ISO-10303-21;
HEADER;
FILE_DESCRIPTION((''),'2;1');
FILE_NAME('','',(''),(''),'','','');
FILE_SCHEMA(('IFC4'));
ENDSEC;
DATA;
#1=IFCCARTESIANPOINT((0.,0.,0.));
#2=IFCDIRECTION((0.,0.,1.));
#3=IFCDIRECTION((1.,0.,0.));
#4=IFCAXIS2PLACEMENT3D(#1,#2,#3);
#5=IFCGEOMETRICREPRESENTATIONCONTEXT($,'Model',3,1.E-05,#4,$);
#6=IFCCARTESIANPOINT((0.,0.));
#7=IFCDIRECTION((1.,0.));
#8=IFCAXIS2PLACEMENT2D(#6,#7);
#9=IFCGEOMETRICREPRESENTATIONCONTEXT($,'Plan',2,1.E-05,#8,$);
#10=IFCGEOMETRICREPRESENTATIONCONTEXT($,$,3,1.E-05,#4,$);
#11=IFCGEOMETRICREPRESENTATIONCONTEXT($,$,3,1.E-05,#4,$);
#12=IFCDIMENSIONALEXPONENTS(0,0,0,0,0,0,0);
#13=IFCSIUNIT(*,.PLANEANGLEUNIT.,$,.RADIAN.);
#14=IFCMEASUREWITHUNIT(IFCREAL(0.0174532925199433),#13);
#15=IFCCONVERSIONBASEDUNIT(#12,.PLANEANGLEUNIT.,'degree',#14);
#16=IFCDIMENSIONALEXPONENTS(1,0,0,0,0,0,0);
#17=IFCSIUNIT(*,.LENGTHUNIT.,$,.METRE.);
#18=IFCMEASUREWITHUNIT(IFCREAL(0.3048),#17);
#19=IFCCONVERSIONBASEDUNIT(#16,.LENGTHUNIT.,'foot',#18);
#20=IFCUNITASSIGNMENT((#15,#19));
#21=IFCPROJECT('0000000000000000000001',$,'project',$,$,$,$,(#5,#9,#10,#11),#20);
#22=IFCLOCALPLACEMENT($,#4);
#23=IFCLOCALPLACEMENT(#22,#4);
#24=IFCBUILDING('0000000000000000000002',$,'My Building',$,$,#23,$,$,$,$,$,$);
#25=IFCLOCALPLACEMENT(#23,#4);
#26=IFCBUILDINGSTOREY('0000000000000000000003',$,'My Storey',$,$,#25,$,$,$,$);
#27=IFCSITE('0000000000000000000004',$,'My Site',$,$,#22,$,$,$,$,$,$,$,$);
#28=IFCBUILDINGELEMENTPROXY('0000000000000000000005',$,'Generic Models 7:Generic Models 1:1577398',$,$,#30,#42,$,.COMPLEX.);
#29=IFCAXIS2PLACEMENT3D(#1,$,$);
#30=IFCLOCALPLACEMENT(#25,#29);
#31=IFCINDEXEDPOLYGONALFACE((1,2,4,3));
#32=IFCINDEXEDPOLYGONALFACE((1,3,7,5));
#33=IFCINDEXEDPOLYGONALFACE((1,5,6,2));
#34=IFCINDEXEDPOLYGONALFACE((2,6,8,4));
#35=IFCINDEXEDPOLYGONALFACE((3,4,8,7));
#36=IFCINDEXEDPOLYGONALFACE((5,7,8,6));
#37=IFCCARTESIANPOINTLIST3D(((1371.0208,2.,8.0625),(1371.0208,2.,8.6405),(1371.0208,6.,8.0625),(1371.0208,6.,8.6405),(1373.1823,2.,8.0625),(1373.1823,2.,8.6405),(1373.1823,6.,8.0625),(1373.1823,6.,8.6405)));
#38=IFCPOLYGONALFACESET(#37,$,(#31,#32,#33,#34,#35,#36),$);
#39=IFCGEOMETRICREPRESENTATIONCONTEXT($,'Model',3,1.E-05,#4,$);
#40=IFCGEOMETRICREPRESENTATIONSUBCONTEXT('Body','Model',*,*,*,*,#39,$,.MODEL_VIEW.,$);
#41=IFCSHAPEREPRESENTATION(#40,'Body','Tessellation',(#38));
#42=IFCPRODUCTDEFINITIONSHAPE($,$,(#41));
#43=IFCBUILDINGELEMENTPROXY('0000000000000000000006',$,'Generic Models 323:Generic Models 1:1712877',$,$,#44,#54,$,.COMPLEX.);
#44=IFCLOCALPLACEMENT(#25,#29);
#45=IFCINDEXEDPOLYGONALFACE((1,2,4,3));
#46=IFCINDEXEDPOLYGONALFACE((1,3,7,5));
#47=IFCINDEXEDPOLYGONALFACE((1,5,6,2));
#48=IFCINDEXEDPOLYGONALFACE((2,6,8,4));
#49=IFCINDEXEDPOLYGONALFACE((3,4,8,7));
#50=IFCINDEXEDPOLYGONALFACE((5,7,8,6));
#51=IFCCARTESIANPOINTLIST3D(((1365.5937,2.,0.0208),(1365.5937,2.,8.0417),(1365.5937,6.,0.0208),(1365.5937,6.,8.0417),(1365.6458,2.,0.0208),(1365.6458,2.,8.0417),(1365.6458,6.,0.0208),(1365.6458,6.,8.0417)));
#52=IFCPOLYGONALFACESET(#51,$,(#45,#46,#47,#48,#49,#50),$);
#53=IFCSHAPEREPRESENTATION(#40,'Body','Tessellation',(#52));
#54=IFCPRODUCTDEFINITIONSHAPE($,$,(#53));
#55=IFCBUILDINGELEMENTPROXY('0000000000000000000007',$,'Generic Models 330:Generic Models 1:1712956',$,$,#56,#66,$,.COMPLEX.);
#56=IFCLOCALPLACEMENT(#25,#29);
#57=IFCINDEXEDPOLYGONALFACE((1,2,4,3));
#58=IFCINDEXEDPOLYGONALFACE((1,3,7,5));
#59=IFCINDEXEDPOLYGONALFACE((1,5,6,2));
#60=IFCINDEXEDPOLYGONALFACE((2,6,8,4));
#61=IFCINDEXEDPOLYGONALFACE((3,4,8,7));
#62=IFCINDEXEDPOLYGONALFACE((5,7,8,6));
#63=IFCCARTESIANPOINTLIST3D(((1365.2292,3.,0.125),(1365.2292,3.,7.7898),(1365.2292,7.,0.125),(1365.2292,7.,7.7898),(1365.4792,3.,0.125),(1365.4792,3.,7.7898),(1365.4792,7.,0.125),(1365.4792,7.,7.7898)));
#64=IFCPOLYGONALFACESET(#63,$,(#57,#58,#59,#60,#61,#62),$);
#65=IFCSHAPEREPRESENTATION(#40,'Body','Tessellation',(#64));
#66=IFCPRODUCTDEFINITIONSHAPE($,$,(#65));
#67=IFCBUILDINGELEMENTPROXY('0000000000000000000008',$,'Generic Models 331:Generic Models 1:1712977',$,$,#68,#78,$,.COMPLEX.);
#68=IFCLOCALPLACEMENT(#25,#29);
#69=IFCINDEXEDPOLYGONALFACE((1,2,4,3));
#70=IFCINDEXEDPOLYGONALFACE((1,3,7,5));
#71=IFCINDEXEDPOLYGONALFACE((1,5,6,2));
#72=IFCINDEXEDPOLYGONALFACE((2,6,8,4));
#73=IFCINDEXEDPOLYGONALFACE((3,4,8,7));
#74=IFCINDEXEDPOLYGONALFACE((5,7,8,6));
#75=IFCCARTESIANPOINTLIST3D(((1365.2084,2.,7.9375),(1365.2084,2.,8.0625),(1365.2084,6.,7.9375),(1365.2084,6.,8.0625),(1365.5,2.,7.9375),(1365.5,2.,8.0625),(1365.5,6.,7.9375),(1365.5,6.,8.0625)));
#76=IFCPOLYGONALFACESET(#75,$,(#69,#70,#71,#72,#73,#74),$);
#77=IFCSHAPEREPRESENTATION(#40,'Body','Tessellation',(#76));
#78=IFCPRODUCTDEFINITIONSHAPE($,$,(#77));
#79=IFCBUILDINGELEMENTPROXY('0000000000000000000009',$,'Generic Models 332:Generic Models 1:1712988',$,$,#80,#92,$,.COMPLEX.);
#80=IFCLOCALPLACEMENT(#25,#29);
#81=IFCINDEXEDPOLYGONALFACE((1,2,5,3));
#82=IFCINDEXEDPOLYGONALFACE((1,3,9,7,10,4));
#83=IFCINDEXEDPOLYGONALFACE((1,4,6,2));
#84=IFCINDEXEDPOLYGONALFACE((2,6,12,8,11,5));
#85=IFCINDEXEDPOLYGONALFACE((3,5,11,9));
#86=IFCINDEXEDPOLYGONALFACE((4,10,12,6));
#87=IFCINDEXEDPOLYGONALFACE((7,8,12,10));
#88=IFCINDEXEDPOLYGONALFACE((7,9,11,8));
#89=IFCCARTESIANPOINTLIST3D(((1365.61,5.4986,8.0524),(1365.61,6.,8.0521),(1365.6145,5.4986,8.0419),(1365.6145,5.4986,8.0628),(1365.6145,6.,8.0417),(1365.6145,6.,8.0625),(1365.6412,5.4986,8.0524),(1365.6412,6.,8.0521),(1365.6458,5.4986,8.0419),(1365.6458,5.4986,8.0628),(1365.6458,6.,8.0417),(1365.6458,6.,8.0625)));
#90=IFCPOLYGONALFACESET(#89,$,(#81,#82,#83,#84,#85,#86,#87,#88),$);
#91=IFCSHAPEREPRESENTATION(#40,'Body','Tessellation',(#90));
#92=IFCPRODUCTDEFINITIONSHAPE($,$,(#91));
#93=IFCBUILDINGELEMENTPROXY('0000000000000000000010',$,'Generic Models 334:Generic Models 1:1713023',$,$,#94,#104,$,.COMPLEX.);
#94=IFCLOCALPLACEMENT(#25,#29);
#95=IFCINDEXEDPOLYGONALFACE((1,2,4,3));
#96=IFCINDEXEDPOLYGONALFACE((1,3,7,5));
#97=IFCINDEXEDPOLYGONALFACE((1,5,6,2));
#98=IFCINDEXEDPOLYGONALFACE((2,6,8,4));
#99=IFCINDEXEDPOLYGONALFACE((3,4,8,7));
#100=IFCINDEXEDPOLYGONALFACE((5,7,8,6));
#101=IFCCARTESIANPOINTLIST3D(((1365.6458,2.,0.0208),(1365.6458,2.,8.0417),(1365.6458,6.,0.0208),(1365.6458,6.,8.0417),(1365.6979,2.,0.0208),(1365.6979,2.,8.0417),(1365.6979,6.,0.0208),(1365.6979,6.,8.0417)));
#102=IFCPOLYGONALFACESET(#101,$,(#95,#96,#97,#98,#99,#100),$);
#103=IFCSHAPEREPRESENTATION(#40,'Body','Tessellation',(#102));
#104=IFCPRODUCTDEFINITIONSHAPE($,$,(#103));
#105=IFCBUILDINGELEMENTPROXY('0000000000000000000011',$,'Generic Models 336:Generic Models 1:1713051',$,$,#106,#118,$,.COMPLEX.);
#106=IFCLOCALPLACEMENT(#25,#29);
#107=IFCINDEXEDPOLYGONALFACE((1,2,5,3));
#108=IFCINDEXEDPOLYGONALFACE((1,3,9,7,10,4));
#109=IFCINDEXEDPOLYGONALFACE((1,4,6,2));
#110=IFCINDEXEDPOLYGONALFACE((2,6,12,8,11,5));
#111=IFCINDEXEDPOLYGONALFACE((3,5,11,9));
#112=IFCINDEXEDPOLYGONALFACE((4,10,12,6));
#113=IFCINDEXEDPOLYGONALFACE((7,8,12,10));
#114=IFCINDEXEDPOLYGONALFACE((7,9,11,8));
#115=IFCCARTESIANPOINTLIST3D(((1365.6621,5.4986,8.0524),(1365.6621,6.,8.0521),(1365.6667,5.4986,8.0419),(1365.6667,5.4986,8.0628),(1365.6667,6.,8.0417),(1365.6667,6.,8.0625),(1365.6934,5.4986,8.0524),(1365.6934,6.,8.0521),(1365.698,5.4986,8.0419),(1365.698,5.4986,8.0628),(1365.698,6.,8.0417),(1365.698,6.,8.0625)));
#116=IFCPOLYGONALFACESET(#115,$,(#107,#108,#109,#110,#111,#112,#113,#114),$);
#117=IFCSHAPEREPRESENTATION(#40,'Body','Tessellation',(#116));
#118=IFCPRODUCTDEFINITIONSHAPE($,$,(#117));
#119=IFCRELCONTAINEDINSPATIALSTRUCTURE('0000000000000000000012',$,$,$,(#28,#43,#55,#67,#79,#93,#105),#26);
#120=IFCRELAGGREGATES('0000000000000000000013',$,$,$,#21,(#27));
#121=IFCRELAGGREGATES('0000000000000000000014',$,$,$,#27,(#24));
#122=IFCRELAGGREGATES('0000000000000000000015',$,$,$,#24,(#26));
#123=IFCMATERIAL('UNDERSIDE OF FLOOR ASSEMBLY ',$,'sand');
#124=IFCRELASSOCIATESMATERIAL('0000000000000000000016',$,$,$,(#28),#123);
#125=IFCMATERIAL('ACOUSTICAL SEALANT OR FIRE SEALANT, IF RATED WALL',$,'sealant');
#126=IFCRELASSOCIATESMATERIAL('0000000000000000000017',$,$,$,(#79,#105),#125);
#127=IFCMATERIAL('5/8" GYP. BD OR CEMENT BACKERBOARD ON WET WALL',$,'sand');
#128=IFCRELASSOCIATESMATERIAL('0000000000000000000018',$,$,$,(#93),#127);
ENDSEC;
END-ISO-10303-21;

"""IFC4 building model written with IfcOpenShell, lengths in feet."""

from ifc_helpers import new_model, entity, si_unit, converted_unit, frame, origin_with_axes, origin_2d_with_axis, place, context, subcontext, project, spatial, polyline, outline, extrude, material, element, save


model = new_model("IFC4")

# Units and contexts
model_context_1 = context("Model", 3, precision=1e-05, world=origin_with_axes())
plan_context = context("Plan", 2, precision=1e-05, world=origin_2d_with_axis())
model_context_2 = context("Model", 3, precision=1e-05, world=origin_with_axes())
context_of_model_1 = context(None, 3, precision=1e-05, world=origin_with_axes())
context_of_model_2 = context(None, 3, precision=1e-05, world=origin_with_axes())
body_context = subcontext(model_context_2, "Body", "Model", "MODEL_VIEW")
ifc_project = project(units=[converted_unit("PLANEANGLEUNIT", "degree", entity("IfcReal", 0.0174532925199433), si_unit("PLANEANGLEUNIT", "RADIAN"), dimensions=[0, 0, 0, 0, 0, 0, 0]), converted_unit("LENGTHUNIT", "foot", entity("IfcReal", 0.3048), si_unit("LENGTHUNIT", "METRE"), dimensions=[1, 0, 0, 0, 0, 0, 0])], contexts=[model_context_1, plan_context, context_of_model_1, context_of_model_2])

# Site, building, storey
site_placement = place(None, origin_with_axes())
site = spatial("IfcSite", under=ifc_project, at=site_placement, Name="My Site")
building_placement = place(site_placement, origin_with_axes())
building = spatial("IfcBuilding", under=site, at=building_placement, Name="My Building")
storey_placement = place(building_placement, origin_with_axes())
storey = spatial("IfcBuildingStorey", under=building, at=storey_placement, Name="My Storey")

# Building element proxies
ifc_material_1 = material(Name="UNDERSIDE OF FLOOR ASSEMBLY ", Category="sand")
ifc_material_2 = material(Name="5/8\" GYP. BD OR CEMENT BACKERBOARD ON WET WALL", Category="sand")
proxy_1_placement = place(storey_placement, frame((1371.0208, 6.0, 8.0625), z_axis=(0.0, -1.0, 0.0), x_axis=(0.0, 0.0, -1.0)))
element("IfcBuildingElementProxy", 1, at=proxy_1_placement, inside=storey, material=ifc_material_1, Name="Generic Models 7:Generic Models 1:1577398", PredefinedType="COMPLEX", context=body_context, shape_type="SweptSolid", body=[
    extrude(outline(polyline([(-0.289, -1.0807), (0.289, -1.0807), (0.289, 1.0807), (-0.289, 1.0807), (-0.289, -1.0807)])), frame((-0.289, 1.0807, 0.0), z_axis=(0.0, 0.0, -1.0), x_axis=(-1.0, 0.0, 0.0)), (0.0, 0.0, -1.0), 4.0),
])
proxy_2_placement = place(storey_placement, frame((1365.5937, 6.0, 0.0208), z_axis=(0.0, -1.0, 0.0), x_axis=(0.0, 0.0, 1.0)))
element("IfcBuildingElementProxy", 2, at=proxy_2_placement, inside=storey, Name="Generic Models 323:Generic Models 1:1712877", PredefinedType="COMPLEX", context=body_context, shape_type="SweptSolid", body=[
    extrude(outline(polyline([(-4.0104, -0.026), (4.0104, -0.026), (4.0104, 0.026), (-4.0104, 0.026), (-4.0104, -0.026)])), frame((4.0104, -0.026, 0.0), z_axis=(0.0, 0.0, -1.0), x_axis=(1.0, 0.0, 0.0)), (0.0, 0.0, -1.0), 4.0),
])
ifc_material_3 = material(Name="ACOUSTICAL SEALANT OR FIRE SEALANT, IF RATED WALL", Category="sealant")
proxy_3_placement = place(storey_placement, frame((1365.2292, 3.0, 0.125), z_axis=(0.0, 0.0, 1.0), x_axis=(0.0, 1.0, 0.0)))
element("IfcBuildingElementProxy", 3, at=proxy_3_placement, inside=storey, Name="Generic Models 330:Generic Models 1:1712956", PredefinedType="COMPLEX", context=body_context, shape_type="SweptSolid", body=[
    extrude(outline(polyline([(-2.0, -0.125), (2.0, -0.125), (2.0, 0.125), (-2.0, 0.125), (-2.0, -0.125)])), frame((2.0, -0.125, 0.0), z_axis=(0.0, 0.0, -1.0), x_axis=(-1.0, 0.0, 0.0)), (0.0, 0.0, -1.0), 7.6648),
])
proxy_4_placement = place(storey_placement, frame((1365.2084, 6.0, 7.9375), z_axis=(0.0, -1.0, 0.0), x_axis=(0.0, 0.0, 1.0)))
element("IfcBuildingElementProxy", 4, at=proxy_4_placement, inside=storey, Name="Generic Models 331:Generic Models 1:1712977", PredefinedType="COMPLEX", context=body_context, shape_type="SweptSolid", body=[
    extrude(outline(polyline([(-0.1458, -0.0625), (0.1458, -0.0625), (0.1458, 0.0625), (-0.1458, 0.0625), (-0.1458, -0.0625)])), frame((0.0625, -0.1458, 0.0), z_axis=(0.0, 0.0, -1.0), x_axis=(0.0, 1.0, 0.0)), (0.0, 0.0, -1.0), 4.0),
])
proxy_5_placement = place(storey_placement, frame((1365.6101, 6.0, 8.0417), z_axis=(0.0, -1.0, 0.0), x_axis=(0.0, 0.0, 1.0)))
element("IfcBuildingElementProxy", 5, at=proxy_5_placement, inside=storey, material=ifc_material_3, Name="Generic Models 332:Generic Models 1:1712988", PredefinedType="COMPLEX", context=body_context, shape_type="SweptSolid", body=[
    extrude(outline(polyline([(0.0201, 0.0), (0.0107, 0.0065), (0.0093, 0.0178), (-0.0175, 0.0016), (-0.016, -0.0097), (-0.0066, -0.0162), (0.0201, 0.0)])), frame((0.0104, -0.0186, 0.0), z_axis=(0.0, 0.0, -1.0), x_axis=(0.51911, -0.854707, 0.0)), (0.000294, -0.000474, -1.0), 0.5014),
])
proxy_6_placement = place(storey_placement, frame((1365.6458, 6.0, 0.0208), z_axis=(0.0, -1.0, 0.0), x_axis=(0.0, 0.0, 1.0)))
element("IfcBuildingElementProxy", 6, at=proxy_6_placement, inside=storey, material=ifc_material_2, Name="Generic Models 334:Generic Models 1:1713023", PredefinedType="COMPLEX", context=body_context, shape_type="SweptSolid", body=[
    extrude(outline(polyline([(-4.0104, -0.026), (4.0104, -0.026), (4.0104, 0.026), (-4.0104, 0.026), (-4.0104, -0.026)])), frame((4.0104, -0.026, 0.0), z_axis=(0.0, 0.0, -1.0), x_axis=(1.0, 0.0, 0.0)), (0.0, 0.0, -1.0), 4.0),
])
proxy_7_placement = place(storey_placement, frame((1365.6622, 6.0, 8.0417), z_axis=(0.0, -1.0, 0.0), x_axis=(0.0, 0.0, 1.0)))
element("IfcBuildingElementProxy", 7, at=proxy_7_placement, inside=storey, material=ifc_material_3, Name="Generic Models 336:Generic Models 1:1713051", PredefinedType="COMPLEX", context=body_context, shape_type="SweptSolid", body=[
    extrude(outline(polyline([(0.0201, 0.0), (0.0107, 0.0065), (0.0093, 0.0178), (-0.0175, 0.0016), (-0.016, -0.0097), (-0.0066, -0.0162), (0.0201, 0.0)])), frame((0.0104, -0.0186, 0.0), z_axis=(0.0, 0.0, -1.0), x_axis=(0.51911, -0.854707, 0.0)), (0.000294, -0.000474, -1.0), 0.5014),
])

save(model, "model.ifc")
